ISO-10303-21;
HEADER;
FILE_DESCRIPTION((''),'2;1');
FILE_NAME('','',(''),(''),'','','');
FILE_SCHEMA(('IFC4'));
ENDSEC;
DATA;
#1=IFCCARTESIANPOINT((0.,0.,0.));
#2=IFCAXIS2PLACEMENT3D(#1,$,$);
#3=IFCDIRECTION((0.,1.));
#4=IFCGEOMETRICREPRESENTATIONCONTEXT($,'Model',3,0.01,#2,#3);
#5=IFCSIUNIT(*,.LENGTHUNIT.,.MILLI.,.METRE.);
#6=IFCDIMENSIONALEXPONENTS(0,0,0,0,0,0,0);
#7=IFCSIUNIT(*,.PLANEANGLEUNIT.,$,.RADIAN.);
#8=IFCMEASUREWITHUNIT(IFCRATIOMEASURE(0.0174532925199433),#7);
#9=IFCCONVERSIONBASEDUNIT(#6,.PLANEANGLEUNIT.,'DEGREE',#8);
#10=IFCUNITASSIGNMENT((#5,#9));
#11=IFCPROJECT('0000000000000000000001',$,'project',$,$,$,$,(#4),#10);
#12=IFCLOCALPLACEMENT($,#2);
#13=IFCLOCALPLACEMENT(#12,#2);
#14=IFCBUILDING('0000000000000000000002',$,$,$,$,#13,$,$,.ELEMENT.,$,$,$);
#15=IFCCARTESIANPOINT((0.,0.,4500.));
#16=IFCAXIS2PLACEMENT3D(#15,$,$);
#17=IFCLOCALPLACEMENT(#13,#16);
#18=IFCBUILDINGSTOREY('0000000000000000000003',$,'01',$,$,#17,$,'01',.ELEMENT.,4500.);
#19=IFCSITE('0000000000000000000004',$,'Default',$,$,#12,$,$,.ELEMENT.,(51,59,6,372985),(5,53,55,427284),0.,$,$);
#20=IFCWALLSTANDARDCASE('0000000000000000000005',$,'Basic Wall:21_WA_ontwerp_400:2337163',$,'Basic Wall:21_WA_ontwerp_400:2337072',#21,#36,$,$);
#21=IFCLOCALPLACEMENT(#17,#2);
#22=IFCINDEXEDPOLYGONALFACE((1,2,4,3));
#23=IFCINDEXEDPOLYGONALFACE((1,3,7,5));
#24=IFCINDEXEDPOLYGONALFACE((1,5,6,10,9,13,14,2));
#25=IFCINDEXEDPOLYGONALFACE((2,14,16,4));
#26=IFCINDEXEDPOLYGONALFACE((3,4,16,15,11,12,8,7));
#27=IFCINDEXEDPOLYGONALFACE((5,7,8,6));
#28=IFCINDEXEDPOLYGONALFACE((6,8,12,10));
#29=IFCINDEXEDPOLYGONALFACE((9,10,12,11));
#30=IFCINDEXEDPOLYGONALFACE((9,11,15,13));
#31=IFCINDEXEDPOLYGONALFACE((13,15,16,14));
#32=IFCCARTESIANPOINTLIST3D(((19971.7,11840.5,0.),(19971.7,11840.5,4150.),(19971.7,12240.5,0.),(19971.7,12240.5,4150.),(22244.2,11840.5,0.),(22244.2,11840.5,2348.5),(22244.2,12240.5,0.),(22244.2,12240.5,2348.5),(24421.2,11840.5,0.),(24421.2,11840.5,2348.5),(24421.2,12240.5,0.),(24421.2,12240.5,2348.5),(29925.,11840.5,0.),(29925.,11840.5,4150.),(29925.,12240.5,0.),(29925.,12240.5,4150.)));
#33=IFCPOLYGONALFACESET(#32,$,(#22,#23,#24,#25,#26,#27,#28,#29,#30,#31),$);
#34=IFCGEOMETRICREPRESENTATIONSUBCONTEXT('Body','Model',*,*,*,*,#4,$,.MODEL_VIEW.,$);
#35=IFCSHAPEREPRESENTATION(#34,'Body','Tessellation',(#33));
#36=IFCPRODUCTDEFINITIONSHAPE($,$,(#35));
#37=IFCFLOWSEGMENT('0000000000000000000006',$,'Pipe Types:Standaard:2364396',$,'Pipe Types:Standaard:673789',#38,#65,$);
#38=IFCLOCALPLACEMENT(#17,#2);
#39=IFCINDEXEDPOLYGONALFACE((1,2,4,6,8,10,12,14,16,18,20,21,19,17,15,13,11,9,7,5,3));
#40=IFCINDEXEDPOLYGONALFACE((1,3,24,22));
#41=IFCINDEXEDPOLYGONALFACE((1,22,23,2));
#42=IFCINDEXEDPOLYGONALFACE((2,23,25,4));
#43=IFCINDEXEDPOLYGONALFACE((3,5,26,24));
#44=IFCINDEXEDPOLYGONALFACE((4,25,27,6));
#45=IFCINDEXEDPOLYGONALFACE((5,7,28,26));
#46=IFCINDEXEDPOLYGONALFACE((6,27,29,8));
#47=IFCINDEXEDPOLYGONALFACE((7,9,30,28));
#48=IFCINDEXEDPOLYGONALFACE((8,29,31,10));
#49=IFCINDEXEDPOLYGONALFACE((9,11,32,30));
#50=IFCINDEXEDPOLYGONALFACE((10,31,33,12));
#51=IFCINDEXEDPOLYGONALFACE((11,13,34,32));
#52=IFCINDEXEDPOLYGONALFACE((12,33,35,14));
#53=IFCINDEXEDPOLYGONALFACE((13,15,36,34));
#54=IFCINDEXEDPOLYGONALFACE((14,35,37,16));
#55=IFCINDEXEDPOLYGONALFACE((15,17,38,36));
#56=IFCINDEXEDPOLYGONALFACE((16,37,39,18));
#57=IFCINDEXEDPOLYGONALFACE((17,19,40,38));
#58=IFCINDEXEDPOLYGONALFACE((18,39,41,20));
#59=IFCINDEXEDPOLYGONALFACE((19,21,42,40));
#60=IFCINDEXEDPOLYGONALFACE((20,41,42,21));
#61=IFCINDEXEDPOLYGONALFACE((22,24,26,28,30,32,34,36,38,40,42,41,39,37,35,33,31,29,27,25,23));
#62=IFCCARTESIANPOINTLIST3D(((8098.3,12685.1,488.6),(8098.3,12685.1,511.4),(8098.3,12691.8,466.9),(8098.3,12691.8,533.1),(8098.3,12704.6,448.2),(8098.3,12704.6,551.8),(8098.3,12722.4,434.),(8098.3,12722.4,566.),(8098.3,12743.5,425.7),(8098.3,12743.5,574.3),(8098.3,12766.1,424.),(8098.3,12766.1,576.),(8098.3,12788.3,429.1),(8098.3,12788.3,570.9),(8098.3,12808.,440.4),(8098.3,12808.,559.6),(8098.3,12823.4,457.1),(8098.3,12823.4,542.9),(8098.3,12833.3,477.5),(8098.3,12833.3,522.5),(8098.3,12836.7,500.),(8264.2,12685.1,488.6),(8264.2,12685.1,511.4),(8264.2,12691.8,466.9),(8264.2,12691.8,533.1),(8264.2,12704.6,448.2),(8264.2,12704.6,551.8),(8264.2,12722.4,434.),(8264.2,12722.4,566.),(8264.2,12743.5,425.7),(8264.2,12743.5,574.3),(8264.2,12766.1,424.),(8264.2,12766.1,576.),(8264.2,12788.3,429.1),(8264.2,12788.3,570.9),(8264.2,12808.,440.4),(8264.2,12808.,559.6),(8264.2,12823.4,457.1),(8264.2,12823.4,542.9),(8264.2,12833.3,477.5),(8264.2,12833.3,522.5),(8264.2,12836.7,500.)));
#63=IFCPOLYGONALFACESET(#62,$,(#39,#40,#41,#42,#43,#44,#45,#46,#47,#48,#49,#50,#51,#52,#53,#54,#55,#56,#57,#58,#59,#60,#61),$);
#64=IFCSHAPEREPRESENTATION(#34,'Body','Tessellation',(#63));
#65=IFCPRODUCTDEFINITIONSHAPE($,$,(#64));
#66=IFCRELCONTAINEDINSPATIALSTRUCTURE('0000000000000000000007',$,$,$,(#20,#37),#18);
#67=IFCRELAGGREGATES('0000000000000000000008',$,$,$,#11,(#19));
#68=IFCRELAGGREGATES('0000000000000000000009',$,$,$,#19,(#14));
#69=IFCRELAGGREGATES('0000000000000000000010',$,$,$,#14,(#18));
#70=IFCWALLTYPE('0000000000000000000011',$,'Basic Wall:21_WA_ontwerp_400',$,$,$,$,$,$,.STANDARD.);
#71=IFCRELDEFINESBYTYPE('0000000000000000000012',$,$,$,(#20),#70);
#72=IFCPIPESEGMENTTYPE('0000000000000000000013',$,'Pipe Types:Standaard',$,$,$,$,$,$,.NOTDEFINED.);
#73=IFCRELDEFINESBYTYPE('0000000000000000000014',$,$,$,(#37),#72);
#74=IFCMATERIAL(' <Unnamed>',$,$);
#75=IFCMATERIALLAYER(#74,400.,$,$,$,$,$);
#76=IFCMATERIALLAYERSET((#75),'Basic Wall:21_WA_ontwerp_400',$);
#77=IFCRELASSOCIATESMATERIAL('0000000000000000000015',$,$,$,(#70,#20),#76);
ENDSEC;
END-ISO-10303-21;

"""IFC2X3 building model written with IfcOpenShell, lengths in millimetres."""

from ifc_helpers import new_model, entity, si_unit, converted_unit, direction, frame, frame_2d, origin, origin_2d_with_axis, place, context, subcontext, project, spatial, rectangle, circle, extrude, material, layer, layer_set, layer_usage, type_object, element, save


model = new_model("IFC2X3")

# Units and contexts
model_context = context("Model", 3, precision=0.01, world=origin(), true_north=direction((0.0, 1.0)))
body_context = subcontext(model_context, "Body", "Model", "MODEL_VIEW")
ifc_project = project(units=[si_unit("LENGTHUNIT", "METRE", prefix="MILLI"), converted_unit("PLANEANGLEUNIT", "DEGREE", entity("IfcRatioMeasure", 0.0174532925199433), si_unit("PLANEANGLEUNIT", "RADIAN"), dimensions=[0, 0, 0, 0, 0, 0, 0])], contexts=[model_context])

# Site, building, storey
site_placement = place(None, origin())
site = spatial("IfcSite", under=ifc_project, at=site_placement, Name="Default", CompositionType="ELEMENT", RefLatitude=(51, 59, 6, 372985), RefLongitude=(5, 53, 55, 427284), RefElevation=0.0)
building_placement = place(site_placement, origin())
building = spatial("IfcBuilding", under=site, at=building_placement, CompositionType="ELEMENT")
storey_placement = place(building_placement, frame((0.0, 0.0, 4500.0)))
storey = spatial("IfcBuildingStorey", under=building, at=storey_placement, Name="01", LongName="01", CompositionType="ELEMENT", Elevation=4500.0)

# Wall, opening
ifc_material_1 = material(Name=" <Unnamed>")
ifc_layer_1 = layer(ifc_material_1, 400.0)
ifc_layer_set_1 = layer_set([ifc_layer_1], Name="Basic Wall:21_WA_ontwerp_400")
ifc_layer_usage_1 = layer_usage(ifc_layer_set_1, "AXIS2", "NEGATIVE", 200.0)
wall_type = type_object("IfcWallType", Name="Basic Wall:21_WA_ontwerp_400", PredefinedType="STANDARD", material=ifc_layer_set_1)
wall_placement = place(storey_placement, frame((19971.7, 12040.5, 0.0)))
wall = element("IfcWallStandardCase", 1, at=wall_placement, inside=storey, type_object=wall_type, material=ifc_layer_usage_1, Name="Basic Wall:21_WA_ontwerp_400:2337163", ObjectType="Basic Wall:21_WA_ontwerp_400:2337072", context=body_context, shape_type="SweptSolid", body=[
    extrude(rectangle(XDim=9953.3, YDim=400.0, at=frame_2d((4976.7, 0.0), x_axis=(-1.0, 0.0))), origin(), (0.0, 0.0, 1.0), 4150.0),
])
opening_placement = place(wall_placement, frame((-19971.7, -12040.5, 0.0)))
element("IfcOpeningElement", 2, at=opening_placement, cuts=wall, ObjectType="Opening", context=body_context, shape_type="SweptSolid", body=[
    extrude(rectangle(XDim=2398.5, YDim=2177.0, at=origin_2d_with_axis()), frame((23332.7, 11840.5, 1149.3), z_axis=(0.0, 1.0, 0.0), x_axis=(0.0, 0.0, -1.0)), (0.0, 0.0, 1.0), 400.0),
])

# Flow segment
pipe_segment_type = type_object("IfcPipeSegmentType", Name="Pipe Types:Standaard", PredefinedType="NOTDEFINED")
flow_segment_placement = place(storey_placement, origin())
element("IfcFlowSegment", 3, at=flow_segment_placement, inside=storey, type_object=pipe_segment_type, Name="Pipe Types:Standaard:2364396", ObjectType="Pipe Types:Standaard:673789", context=body_context, shape_type="SweptSolid", body=[
    extrude(circle(Radius=76.2, at=origin_2d_with_axis()), frame((8098.3, 12760.5, 500.0), z_axis=(1.0, 0.0, 0.0), x_axis=(0.0, 1.0, 0.0)), (0.0, 0.0, 1.0), 165.9),
])

save(model, "model.ifc")
